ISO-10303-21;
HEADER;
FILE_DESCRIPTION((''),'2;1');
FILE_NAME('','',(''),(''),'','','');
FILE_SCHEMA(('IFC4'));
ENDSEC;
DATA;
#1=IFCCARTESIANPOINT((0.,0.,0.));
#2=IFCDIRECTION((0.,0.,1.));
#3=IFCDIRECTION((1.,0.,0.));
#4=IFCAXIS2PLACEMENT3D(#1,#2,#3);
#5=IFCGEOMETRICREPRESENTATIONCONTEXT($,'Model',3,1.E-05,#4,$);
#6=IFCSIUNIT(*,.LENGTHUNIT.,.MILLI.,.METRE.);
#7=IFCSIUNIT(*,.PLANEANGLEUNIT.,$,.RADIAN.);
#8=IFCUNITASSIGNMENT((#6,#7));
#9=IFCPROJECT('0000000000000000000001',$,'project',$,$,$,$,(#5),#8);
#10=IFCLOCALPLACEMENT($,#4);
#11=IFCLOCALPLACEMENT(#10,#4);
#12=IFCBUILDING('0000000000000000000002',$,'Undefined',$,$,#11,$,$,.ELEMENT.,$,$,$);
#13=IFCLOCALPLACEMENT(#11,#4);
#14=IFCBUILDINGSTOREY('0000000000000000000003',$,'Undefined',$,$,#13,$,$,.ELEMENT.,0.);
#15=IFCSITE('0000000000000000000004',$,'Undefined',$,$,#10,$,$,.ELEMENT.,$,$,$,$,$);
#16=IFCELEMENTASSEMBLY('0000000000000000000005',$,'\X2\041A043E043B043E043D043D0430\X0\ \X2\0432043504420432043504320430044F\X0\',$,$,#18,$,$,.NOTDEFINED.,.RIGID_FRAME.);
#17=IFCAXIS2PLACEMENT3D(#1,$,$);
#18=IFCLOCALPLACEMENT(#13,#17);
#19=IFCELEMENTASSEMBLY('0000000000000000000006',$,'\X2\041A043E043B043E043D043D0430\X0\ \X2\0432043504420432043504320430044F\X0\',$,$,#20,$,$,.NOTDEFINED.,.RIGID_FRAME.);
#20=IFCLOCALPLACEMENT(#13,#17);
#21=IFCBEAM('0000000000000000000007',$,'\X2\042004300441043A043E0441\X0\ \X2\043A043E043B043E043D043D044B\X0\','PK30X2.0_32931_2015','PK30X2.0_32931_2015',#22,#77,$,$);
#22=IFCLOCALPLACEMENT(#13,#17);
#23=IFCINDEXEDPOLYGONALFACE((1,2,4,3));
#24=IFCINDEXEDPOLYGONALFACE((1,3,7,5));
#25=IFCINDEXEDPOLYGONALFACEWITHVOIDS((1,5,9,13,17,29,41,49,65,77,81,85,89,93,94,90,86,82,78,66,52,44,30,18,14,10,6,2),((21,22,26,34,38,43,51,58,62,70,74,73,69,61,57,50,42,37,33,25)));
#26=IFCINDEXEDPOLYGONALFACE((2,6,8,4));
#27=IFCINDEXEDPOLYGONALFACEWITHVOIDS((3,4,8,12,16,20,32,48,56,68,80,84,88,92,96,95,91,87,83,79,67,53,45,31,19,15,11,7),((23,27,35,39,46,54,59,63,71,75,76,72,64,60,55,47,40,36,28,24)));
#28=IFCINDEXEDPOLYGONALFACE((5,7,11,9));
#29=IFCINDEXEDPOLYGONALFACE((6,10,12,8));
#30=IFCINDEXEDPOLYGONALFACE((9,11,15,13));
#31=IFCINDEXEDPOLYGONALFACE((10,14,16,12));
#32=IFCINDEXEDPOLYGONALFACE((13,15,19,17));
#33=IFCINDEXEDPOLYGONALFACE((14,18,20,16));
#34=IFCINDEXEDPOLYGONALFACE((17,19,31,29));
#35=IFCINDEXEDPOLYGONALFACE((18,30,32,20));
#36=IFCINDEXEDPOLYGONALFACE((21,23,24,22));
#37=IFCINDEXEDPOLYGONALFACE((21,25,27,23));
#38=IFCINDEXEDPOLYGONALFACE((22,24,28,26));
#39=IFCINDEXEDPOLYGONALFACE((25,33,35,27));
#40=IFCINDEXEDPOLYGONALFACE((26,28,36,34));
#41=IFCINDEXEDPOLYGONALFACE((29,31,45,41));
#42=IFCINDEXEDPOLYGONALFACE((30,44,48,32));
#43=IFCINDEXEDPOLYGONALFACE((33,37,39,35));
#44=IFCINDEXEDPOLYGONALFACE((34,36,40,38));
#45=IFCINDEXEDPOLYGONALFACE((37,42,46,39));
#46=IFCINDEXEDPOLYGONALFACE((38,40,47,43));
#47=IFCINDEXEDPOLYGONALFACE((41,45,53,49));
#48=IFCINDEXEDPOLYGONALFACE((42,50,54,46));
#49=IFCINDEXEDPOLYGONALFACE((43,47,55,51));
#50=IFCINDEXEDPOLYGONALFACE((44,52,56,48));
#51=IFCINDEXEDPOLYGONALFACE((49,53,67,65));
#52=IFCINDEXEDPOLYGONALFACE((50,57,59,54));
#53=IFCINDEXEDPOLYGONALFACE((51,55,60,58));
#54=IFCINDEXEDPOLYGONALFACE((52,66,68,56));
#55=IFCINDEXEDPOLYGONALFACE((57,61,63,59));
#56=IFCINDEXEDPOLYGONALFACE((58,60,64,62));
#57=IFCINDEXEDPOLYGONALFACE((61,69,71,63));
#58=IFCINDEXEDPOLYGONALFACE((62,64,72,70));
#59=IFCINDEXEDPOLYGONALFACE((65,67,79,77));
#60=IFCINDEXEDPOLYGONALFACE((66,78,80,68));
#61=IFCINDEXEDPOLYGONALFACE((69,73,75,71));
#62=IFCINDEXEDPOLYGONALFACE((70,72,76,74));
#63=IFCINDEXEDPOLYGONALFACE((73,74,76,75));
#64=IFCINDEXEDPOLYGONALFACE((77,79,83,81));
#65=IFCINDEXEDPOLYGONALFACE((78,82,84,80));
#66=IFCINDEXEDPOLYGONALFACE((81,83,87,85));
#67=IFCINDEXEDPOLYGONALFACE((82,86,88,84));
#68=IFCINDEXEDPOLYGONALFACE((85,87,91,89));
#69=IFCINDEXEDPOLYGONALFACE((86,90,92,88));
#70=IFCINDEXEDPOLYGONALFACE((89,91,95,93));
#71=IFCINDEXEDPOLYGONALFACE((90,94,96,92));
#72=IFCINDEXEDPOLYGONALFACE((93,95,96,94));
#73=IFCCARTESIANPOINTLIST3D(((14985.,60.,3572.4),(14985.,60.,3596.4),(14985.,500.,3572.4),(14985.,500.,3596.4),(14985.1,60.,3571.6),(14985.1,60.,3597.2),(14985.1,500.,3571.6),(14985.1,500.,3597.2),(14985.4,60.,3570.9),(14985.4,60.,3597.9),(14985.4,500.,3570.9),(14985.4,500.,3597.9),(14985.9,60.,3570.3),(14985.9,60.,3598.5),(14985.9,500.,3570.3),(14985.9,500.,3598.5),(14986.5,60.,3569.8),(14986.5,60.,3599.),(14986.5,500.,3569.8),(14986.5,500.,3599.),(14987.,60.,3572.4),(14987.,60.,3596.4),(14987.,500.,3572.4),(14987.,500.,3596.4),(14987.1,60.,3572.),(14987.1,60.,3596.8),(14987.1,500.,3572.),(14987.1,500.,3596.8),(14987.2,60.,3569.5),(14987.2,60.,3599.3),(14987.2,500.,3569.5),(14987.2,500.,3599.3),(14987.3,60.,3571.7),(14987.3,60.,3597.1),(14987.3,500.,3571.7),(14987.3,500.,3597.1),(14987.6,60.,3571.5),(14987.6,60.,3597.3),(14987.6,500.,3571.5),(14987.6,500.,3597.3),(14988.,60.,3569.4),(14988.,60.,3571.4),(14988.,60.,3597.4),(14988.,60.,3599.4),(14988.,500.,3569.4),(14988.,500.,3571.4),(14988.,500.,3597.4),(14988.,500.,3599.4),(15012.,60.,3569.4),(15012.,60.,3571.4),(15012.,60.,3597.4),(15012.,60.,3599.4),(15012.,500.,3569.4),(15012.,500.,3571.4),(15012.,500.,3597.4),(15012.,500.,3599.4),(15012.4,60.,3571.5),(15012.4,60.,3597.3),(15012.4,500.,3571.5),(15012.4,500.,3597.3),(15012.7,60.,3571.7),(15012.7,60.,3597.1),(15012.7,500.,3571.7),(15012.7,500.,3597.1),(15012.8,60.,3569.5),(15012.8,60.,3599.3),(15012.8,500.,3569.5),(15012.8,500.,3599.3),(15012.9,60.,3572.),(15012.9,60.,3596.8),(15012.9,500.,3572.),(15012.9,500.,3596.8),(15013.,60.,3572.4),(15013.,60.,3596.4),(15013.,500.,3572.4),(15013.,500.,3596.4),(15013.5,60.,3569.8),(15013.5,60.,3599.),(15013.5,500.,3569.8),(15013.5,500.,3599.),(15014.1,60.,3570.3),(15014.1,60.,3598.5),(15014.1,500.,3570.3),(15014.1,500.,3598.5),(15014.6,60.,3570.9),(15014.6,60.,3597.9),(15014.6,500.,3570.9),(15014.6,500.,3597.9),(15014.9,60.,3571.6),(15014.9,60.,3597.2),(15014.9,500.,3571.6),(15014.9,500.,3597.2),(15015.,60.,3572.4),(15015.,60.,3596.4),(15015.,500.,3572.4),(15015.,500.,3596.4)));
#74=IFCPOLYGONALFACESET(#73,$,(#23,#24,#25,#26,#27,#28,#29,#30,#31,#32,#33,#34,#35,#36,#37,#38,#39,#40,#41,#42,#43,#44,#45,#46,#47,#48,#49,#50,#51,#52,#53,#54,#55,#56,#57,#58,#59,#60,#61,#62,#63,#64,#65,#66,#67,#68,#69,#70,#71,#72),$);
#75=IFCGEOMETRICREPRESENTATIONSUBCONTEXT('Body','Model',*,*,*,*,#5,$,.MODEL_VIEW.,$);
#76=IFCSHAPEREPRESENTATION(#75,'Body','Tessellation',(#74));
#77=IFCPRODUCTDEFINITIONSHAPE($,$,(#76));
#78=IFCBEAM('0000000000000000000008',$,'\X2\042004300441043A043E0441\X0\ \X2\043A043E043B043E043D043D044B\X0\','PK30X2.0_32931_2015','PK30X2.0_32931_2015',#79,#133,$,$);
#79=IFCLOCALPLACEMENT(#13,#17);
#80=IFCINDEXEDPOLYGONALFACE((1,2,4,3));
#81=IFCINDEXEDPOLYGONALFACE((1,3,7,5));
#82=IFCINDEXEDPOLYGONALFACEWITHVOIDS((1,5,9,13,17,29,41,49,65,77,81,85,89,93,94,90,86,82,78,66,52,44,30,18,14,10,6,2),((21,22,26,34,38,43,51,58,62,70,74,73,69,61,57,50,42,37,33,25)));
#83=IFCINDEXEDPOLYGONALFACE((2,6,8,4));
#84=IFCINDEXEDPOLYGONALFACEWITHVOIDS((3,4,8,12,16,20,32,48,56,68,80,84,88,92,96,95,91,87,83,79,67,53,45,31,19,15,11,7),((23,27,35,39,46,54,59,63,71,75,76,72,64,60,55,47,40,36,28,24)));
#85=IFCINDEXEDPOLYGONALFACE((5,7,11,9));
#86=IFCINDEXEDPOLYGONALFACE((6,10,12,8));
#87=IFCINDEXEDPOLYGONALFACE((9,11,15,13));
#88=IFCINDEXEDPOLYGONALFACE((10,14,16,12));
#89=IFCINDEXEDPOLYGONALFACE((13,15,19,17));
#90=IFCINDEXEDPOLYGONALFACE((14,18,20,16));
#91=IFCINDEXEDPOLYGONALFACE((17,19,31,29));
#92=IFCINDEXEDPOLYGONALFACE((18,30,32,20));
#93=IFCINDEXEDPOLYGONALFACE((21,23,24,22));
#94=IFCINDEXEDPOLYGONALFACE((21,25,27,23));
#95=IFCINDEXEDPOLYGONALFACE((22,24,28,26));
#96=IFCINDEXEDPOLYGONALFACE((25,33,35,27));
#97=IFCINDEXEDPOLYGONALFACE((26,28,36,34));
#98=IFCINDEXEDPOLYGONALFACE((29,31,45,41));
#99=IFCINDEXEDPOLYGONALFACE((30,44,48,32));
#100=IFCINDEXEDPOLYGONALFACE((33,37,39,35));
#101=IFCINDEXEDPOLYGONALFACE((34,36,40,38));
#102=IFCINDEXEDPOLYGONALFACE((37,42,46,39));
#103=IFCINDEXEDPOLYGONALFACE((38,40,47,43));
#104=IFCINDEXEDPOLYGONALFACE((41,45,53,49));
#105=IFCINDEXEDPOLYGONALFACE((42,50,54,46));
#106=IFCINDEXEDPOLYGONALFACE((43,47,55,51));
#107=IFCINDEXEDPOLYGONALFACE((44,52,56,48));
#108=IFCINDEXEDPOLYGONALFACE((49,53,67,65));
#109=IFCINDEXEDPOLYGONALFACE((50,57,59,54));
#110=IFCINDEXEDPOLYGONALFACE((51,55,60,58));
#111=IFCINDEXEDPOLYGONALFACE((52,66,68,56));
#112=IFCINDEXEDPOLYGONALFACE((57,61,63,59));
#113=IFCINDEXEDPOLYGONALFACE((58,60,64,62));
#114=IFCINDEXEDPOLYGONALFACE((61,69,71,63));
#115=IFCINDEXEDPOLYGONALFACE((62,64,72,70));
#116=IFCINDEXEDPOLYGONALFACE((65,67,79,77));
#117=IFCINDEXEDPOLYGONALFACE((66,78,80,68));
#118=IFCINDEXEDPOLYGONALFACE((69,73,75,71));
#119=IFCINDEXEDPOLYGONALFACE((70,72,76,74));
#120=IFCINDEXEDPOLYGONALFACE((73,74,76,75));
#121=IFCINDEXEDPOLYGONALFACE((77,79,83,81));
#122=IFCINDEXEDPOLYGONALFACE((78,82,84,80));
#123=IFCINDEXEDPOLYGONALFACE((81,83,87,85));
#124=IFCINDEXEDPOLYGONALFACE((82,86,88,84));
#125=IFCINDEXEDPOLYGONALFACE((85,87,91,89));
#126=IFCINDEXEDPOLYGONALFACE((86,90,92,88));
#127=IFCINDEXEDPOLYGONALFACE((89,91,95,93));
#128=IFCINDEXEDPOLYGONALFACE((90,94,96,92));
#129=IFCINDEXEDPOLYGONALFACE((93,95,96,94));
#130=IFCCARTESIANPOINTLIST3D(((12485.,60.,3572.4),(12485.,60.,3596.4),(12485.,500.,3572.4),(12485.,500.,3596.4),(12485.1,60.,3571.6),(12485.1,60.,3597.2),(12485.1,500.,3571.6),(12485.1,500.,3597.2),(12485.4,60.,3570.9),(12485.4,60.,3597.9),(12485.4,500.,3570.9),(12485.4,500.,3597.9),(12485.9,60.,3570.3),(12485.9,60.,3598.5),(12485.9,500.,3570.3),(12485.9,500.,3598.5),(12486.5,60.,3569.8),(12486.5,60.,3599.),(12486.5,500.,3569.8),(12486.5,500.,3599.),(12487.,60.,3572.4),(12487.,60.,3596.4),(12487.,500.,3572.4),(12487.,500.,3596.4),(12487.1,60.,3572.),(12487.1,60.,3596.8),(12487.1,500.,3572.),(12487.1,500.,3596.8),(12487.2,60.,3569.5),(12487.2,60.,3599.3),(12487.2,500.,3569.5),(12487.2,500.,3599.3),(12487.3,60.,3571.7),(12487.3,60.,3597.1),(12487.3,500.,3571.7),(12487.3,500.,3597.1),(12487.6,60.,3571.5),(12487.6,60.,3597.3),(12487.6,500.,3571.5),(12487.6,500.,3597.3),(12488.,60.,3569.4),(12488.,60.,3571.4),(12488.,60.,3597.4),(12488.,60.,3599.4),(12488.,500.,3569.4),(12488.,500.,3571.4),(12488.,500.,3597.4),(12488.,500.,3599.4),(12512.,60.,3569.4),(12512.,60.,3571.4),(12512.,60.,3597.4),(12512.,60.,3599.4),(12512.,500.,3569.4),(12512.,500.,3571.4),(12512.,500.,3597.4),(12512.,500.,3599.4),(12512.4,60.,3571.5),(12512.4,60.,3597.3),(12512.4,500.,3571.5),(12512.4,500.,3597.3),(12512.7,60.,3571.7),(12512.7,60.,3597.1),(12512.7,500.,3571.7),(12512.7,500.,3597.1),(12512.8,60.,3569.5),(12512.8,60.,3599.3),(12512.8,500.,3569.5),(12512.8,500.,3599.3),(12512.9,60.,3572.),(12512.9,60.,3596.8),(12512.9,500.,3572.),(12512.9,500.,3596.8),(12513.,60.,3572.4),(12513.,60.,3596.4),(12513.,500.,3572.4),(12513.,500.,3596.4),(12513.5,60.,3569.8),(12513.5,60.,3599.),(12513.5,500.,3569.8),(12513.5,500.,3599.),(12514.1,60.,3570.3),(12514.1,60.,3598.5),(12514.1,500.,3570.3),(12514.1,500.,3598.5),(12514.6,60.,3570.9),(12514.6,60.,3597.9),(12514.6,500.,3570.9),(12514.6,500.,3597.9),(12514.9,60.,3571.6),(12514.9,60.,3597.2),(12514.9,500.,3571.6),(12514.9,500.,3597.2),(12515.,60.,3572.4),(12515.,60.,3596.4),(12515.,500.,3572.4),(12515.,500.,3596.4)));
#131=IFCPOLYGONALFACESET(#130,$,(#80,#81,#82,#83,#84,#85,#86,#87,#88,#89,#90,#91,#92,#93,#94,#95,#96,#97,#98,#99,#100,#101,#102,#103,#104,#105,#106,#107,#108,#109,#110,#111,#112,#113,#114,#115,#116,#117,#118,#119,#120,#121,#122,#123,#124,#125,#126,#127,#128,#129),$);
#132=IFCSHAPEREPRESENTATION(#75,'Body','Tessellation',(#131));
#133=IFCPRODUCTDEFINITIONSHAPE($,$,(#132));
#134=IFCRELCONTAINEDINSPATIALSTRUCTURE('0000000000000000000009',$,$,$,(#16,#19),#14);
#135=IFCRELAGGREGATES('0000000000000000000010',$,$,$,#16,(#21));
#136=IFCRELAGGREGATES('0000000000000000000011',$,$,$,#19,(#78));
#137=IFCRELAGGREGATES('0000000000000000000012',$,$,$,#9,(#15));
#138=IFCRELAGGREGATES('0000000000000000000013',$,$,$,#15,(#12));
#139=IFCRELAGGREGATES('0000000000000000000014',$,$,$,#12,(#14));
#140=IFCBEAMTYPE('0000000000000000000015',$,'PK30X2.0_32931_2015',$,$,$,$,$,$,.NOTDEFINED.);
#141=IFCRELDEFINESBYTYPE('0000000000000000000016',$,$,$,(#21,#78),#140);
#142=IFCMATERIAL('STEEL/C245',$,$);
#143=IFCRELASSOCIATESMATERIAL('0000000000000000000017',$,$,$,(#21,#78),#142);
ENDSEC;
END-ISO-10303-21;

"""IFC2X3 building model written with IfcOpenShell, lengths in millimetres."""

from ifc_helpers import new_model, si_unit, frame, origin_with_axes, origin_2d_with_axis, place, context, subcontext, project, spatial, hollow_rectangle, extrude, material, type_object, element, aggregate, save


model = new_model("IFC2X3")

# Units and contexts
model_context = context("Model", 3, precision=1e-05, world=origin_with_axes())
body_context = subcontext(model_context, "Body", "Model", "MODEL_VIEW")
ifc_project = project(units=[si_unit("LENGTHUNIT", "METRE", prefix="MILLI"), si_unit("PLANEANGLEUNIT", "RADIAN")], contexts=[model_context])

# Site, building, storey
site_placement = place(None, origin_with_axes())
site = spatial("IfcSite", under=ifc_project, at=site_placement, Name="Undefined", CompositionType="ELEMENT")
building_placement = place(site_placement, origin_with_axes())
building = spatial("IfcBuilding", under=site, at=building_placement, Name="Undefined", CompositionType="ELEMENT")
storey_placement = place(building_placement, origin_with_axes())
storey = spatial("IfcBuildingStorey", under=building, at=storey_placement, Name="Undefined", CompositionType="ELEMENT", Elevation=0.0)

# Shared definitions
ifc_material_1 = material(Name="STEEL/C245")

# Element assembly
assembly_1_placement = place(storey_placement, origin_with_axes())
assembly_1 = element("IfcElementAssembly", 1, at=assembly_1_placement, inside=storey, Name="Колонна ветвевая", AssemblyPlace="NOTDEFINED", PredefinedType="RIGID_FRAME")

# Element assembly
assembly_2_placement = place(storey_placement, origin_with_axes())
assembly_2 = element("IfcElementAssembly", 2, at=assembly_2_placement, inside=storey, Name="Колонна ветвевая", AssemblyPlace="NOTDEFINED", PredefinedType="RIGID_FRAME")

# Beams
beam_type_1 = type_object("IfcBeamType", Name="PK30X2.0_32931_2015", PredefinedType="NOTDEFINED")
beam_1_placement = place(assembly_1_placement, frame((15000.0, 500.0, 3584.4), z_axis=(0.0, 0.0, -1.0), x_axis=(0.0, -1.0, 0.0)))
beam_1 = element("IfcBeam", 3, at=beam_1_placement, type_object=beam_type_1, material=ifc_material_1, Name="Раскос колонны", Description="PK30X2.0_32931_2015", ObjectType="PK30X2.0_32931_2015", context=body_context, shape_type="SweptSolid", body=[
    extrude(hollow_rectangle(XDim=30.0, YDim=30.0, WallThickness=2.0, InnerFilletRadius=1.0, OuterFilletRadius=3.0, at=origin_2d_with_axis()), frame((440.0, 0.0, 0.0), z_axis=(-1.0, 0.0, 0.0), x_axis=(0.0, -1.0, 0.0)), (0.0, 0.0, 1.0), 440.0),
])
aggregate(assembly_1, [beam_1])
beam_2_placement = place(assembly_2_placement, frame((12500.0, 500.0, 3584.4), z_axis=(0.0, 0.0, -1.0), x_axis=(0.0, -1.0, 0.0)))
beam_2 = element("IfcBeam", 4, at=beam_2_placement, type_object=beam_type_1, material=ifc_material_1, Name="Раскос колонны", Description="PK30X2.0_32931_2015", ObjectType="PK30X2.0_32931_2015", context=body_context, shape_type="SweptSolid", body=[
    extrude(hollow_rectangle(XDim=30.0, YDim=30.0, WallThickness=2.0, InnerFilletRadius=1.0, OuterFilletRadius=3.0, at=origin_2d_with_axis()), frame((440.0, 0.0, 0.0), z_axis=(-1.0, 0.0, 0.0), x_axis=(0.0, -1.0, 0.0)), (0.0, 0.0, 1.0), 440.0),
])
aggregate(assembly_2, [beam_2])

save(model, "model.ifc")
